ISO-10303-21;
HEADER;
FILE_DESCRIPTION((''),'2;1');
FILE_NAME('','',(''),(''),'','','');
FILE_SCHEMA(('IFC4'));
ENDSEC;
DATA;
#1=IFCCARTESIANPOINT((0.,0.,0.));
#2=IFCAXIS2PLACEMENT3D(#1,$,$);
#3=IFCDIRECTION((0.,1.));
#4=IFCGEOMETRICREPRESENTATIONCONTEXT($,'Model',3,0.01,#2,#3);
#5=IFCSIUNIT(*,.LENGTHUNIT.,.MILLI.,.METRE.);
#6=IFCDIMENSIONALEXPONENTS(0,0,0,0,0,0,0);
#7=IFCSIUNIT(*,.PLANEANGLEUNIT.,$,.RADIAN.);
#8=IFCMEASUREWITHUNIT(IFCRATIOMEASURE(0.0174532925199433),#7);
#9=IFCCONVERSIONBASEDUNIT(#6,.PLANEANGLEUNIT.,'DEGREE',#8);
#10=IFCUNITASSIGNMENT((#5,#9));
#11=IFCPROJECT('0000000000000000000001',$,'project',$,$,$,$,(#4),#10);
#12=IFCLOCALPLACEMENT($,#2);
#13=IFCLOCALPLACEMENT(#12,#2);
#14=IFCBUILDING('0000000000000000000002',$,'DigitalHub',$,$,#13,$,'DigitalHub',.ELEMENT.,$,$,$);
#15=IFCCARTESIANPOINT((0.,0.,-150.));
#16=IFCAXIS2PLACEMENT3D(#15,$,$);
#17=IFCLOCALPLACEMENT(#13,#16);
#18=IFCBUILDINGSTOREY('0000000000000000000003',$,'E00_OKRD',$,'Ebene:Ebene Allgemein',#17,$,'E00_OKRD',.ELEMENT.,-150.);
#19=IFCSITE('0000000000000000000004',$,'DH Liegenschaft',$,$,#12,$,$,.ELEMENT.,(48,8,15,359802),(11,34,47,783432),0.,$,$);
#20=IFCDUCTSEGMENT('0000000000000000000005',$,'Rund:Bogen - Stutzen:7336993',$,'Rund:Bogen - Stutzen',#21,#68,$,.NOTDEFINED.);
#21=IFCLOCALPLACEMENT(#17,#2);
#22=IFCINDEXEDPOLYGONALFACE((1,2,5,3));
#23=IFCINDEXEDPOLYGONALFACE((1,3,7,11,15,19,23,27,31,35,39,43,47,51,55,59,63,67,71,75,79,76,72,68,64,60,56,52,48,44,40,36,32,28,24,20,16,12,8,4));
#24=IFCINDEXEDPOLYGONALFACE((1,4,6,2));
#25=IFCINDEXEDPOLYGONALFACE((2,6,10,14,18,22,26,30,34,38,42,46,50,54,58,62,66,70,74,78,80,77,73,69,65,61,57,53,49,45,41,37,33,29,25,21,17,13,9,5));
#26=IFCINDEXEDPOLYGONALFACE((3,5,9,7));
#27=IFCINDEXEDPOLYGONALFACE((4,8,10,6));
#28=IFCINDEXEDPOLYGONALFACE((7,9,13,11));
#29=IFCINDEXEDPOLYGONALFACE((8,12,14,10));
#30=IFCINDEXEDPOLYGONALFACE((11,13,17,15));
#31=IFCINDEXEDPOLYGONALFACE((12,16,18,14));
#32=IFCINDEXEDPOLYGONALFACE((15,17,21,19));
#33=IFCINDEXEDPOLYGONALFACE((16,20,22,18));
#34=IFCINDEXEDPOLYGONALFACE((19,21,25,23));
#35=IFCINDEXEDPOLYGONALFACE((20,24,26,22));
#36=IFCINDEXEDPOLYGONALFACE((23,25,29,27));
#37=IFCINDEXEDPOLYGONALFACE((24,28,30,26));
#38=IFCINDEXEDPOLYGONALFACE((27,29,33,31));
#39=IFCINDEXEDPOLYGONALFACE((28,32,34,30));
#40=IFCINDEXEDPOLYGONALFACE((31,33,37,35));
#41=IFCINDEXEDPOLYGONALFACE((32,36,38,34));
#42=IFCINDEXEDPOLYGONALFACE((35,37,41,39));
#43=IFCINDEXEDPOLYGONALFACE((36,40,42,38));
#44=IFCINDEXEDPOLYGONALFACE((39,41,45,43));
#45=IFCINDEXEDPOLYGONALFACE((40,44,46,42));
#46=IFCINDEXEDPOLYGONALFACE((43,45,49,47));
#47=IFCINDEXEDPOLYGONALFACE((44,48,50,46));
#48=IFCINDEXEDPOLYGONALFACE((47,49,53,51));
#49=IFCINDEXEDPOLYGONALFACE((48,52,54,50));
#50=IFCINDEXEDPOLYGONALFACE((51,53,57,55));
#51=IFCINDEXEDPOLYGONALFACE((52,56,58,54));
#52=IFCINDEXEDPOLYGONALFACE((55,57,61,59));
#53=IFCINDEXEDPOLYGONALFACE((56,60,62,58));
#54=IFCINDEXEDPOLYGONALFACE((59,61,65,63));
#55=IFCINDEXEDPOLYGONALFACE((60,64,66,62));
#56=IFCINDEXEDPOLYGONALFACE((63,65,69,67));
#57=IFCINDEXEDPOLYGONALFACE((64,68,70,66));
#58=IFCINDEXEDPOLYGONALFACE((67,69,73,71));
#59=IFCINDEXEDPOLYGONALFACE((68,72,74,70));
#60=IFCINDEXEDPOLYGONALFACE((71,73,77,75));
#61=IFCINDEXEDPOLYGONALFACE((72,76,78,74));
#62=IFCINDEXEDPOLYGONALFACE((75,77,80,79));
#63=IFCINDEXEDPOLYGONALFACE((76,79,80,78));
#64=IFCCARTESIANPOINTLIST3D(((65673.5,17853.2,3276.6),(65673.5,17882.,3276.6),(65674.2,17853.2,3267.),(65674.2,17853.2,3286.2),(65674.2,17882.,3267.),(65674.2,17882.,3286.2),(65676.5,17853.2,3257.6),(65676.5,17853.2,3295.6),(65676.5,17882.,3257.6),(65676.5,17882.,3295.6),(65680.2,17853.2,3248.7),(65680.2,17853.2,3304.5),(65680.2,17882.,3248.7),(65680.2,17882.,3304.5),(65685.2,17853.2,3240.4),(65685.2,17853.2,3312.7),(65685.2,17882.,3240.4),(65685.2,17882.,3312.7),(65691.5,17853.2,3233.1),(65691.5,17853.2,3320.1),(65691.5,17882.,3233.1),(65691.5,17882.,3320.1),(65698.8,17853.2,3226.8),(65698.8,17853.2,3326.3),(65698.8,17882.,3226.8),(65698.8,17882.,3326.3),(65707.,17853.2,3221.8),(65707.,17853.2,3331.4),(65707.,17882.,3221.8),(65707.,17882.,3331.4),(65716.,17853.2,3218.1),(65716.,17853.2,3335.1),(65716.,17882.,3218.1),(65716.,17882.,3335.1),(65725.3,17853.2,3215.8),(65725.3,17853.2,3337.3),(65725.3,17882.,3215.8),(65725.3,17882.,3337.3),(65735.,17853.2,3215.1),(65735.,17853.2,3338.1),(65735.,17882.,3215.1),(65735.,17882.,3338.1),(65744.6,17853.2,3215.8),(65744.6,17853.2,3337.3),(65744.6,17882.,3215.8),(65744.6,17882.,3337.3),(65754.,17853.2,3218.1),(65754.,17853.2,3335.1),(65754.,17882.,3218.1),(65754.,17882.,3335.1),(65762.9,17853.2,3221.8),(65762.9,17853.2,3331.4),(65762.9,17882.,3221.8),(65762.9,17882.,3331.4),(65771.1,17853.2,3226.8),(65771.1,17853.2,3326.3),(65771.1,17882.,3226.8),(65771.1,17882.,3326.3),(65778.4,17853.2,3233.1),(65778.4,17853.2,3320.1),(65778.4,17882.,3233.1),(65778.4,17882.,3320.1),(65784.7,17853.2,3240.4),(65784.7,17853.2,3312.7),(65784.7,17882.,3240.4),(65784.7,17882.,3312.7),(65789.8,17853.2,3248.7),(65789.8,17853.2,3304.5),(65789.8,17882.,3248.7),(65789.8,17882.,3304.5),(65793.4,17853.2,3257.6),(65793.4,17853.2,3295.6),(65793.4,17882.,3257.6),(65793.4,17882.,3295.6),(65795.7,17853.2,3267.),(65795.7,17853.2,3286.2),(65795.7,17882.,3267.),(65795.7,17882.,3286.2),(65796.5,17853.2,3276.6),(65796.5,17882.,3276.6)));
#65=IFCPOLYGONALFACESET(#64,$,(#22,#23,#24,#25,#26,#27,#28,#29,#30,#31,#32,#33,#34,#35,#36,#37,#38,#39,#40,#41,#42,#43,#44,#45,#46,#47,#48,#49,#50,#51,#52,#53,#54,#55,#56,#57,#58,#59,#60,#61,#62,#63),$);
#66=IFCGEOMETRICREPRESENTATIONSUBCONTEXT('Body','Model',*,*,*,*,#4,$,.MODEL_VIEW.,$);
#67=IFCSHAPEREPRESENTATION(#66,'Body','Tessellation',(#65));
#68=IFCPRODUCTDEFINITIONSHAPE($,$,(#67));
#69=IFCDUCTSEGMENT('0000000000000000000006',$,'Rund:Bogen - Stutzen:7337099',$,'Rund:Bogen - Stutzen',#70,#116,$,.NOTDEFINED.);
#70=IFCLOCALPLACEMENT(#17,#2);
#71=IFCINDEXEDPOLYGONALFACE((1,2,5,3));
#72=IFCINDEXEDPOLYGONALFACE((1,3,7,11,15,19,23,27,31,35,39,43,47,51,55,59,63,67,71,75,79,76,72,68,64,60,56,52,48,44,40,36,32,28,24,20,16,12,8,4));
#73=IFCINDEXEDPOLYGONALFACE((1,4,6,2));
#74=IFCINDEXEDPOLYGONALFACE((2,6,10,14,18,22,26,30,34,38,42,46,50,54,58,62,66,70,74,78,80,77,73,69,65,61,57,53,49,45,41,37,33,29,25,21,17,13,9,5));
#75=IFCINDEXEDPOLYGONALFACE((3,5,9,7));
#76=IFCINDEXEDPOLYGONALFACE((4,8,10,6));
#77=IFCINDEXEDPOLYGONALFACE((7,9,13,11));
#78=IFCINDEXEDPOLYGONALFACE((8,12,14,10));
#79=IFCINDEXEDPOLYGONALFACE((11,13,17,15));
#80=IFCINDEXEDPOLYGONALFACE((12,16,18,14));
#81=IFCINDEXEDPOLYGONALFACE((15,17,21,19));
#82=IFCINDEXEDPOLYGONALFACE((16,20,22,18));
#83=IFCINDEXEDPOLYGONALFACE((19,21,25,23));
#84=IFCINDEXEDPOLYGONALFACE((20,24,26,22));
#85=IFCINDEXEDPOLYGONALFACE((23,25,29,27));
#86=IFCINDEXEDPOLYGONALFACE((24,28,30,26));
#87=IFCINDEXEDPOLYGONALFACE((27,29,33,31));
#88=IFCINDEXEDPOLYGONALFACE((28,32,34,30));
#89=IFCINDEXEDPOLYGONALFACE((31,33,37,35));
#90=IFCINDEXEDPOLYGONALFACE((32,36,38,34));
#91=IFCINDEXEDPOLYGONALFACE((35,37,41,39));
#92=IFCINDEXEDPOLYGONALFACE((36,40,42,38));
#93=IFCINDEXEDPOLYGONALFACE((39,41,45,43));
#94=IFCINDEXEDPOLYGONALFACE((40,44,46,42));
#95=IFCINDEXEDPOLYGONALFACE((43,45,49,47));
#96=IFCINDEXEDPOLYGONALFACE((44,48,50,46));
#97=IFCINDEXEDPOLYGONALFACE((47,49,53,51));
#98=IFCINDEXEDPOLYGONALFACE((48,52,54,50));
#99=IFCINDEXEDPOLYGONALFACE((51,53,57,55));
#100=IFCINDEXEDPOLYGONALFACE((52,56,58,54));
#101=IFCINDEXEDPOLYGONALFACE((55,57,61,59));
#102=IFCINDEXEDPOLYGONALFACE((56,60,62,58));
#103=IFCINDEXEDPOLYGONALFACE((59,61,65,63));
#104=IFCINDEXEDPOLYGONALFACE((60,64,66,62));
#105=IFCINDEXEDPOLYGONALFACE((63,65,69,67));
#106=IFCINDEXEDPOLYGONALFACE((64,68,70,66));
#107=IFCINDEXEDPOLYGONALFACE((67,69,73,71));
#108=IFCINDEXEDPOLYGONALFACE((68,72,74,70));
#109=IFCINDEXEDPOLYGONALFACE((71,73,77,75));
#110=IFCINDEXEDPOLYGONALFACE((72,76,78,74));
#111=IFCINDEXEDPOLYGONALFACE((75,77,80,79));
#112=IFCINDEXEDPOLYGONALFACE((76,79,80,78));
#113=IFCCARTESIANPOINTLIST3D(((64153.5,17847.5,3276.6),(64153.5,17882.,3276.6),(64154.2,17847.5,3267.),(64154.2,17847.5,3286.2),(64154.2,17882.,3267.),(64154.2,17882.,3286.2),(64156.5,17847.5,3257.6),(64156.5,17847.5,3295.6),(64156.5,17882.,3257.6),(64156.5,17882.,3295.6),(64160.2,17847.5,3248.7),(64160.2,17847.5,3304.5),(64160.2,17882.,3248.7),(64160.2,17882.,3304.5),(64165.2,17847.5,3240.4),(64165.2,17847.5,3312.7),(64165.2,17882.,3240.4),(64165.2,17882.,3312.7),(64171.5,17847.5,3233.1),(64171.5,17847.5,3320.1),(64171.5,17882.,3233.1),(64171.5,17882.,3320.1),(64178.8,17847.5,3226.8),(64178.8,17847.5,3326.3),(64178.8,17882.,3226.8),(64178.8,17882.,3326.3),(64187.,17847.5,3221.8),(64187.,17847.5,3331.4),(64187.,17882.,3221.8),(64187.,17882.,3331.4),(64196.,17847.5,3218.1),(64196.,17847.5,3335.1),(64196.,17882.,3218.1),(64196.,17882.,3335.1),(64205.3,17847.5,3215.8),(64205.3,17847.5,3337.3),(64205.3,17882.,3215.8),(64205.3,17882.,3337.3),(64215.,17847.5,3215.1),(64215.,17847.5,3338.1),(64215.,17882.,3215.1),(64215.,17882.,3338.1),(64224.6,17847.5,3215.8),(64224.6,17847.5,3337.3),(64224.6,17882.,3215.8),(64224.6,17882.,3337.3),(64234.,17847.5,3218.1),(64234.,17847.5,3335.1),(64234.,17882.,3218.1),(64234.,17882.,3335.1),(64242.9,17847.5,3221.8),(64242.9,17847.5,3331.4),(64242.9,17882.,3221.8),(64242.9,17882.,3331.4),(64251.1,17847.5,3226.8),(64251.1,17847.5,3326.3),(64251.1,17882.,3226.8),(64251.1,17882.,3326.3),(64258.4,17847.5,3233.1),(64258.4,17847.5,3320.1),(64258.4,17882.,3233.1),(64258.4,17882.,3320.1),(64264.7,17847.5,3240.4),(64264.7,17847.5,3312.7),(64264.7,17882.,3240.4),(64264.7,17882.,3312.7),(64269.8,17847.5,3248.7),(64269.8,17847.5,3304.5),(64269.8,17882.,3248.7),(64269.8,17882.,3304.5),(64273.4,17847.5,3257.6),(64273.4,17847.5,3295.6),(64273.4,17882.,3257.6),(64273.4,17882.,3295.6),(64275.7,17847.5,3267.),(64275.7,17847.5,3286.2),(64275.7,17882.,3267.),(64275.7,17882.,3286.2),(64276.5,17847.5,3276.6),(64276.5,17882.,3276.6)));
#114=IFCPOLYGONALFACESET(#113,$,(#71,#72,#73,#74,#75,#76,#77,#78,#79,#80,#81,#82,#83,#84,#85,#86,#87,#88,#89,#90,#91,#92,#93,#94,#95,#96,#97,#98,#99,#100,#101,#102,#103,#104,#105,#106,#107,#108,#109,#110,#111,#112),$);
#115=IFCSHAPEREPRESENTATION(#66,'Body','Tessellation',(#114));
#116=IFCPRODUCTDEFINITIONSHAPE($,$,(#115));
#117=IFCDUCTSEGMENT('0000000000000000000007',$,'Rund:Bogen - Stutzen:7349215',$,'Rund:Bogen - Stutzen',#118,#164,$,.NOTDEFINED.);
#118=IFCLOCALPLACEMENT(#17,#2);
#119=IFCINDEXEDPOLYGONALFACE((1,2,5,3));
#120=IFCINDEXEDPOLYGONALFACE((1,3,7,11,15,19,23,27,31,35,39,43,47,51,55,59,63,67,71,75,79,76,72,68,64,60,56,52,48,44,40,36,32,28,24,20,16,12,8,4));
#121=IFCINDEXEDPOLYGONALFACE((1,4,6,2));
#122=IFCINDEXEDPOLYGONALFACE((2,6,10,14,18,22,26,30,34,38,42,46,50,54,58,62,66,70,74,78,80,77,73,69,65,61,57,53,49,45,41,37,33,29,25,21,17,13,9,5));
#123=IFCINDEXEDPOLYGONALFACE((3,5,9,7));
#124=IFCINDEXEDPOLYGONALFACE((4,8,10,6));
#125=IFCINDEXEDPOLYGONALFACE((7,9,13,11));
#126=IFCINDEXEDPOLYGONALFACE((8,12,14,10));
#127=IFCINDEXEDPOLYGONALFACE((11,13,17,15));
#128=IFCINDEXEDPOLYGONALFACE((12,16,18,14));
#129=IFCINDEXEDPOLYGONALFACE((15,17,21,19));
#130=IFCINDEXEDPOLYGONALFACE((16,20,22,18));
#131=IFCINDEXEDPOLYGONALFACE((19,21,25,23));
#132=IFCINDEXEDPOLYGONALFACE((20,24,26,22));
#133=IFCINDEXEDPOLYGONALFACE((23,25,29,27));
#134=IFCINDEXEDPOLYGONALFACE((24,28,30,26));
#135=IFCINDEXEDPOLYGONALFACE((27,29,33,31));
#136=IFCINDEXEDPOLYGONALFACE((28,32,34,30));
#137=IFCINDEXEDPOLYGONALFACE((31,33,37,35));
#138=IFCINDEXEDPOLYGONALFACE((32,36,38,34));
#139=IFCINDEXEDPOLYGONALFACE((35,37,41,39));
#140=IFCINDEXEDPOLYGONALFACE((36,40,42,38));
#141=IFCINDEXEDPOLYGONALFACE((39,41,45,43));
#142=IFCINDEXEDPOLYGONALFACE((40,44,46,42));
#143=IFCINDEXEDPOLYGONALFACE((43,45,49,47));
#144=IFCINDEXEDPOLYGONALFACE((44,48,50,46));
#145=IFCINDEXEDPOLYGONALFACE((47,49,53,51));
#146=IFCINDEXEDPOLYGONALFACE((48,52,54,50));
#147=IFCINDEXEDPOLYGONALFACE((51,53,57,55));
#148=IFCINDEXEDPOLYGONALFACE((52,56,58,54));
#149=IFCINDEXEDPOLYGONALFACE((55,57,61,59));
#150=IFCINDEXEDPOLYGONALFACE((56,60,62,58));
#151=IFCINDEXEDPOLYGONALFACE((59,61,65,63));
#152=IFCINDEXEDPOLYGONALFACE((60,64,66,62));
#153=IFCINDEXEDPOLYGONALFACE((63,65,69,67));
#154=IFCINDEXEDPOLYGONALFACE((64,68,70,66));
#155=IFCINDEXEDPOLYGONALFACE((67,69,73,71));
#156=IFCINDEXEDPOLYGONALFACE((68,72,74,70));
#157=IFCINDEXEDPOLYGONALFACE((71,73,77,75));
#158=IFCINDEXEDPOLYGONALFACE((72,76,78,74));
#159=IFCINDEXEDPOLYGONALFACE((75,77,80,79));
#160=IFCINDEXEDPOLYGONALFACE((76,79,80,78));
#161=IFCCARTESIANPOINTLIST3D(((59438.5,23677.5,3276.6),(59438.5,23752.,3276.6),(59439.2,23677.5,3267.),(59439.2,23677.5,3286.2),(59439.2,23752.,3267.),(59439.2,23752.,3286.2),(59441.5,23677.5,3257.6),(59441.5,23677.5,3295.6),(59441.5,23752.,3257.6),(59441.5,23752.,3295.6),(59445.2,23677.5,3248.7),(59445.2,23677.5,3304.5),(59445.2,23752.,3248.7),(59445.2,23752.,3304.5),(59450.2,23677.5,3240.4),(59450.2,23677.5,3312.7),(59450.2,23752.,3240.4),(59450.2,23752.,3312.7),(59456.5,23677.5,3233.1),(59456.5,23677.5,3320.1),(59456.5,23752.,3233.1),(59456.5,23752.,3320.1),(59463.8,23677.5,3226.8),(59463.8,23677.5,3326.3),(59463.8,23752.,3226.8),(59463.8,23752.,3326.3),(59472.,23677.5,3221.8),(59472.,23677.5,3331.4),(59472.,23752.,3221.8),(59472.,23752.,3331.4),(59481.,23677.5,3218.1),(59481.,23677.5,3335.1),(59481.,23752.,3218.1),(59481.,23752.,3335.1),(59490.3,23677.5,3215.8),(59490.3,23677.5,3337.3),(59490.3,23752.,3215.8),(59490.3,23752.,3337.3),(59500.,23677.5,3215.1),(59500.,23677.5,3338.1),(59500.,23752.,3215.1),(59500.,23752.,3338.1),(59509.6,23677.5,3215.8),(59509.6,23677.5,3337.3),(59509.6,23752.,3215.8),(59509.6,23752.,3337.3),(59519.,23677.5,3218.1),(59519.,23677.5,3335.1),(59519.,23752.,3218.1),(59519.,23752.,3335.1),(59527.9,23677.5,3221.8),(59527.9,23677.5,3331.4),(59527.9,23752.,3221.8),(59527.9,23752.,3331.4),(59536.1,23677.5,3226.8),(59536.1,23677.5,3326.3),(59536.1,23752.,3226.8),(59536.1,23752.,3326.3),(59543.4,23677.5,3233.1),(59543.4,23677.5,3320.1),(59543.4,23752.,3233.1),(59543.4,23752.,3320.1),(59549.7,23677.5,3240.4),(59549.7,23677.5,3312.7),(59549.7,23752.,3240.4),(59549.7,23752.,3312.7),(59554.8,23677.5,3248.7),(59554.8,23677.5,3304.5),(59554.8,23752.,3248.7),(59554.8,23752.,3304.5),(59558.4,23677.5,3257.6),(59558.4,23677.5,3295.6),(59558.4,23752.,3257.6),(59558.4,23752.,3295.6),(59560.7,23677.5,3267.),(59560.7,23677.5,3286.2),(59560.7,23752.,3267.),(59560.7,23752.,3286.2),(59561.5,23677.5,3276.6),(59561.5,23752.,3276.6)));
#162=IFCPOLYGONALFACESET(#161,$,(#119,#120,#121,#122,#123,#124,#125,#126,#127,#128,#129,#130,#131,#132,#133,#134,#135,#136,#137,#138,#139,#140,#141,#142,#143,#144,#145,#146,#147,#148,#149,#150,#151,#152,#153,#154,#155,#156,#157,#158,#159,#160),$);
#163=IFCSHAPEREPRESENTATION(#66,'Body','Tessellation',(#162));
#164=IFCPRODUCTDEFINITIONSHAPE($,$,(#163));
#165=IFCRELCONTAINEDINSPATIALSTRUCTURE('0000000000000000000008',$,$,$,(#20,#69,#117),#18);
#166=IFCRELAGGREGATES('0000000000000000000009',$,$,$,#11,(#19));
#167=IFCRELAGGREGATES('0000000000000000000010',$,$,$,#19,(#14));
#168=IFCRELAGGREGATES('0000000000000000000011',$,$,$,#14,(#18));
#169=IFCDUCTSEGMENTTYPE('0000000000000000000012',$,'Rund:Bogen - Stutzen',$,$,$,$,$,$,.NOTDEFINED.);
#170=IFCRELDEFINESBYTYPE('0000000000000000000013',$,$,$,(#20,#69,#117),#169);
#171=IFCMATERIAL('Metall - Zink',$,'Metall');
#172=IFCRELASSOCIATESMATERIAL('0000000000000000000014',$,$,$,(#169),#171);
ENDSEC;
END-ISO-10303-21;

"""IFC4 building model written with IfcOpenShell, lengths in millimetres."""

from ifc_helpers import new_model, entity, si_unit, converted_unit, direction, frame, origin, place, context, subcontext, project, spatial, indexed_curve, outline, extrude, material, type_object, element, save


model = new_model("IFC4")

# Units and contexts
model_context = context("Model", 3, precision=0.01, world=origin(), true_north=direction((0.0, 1.0)))
body_context = subcontext(model_context, "Body", "Model", "MODEL_VIEW")
ifc_project = project(units=[si_unit("LENGTHUNIT", "METRE", prefix="MILLI"), converted_unit("PLANEANGLEUNIT", "DEGREE", entity("IfcRatioMeasure", 0.0174532925199433), si_unit("PLANEANGLEUNIT", "RADIAN"), dimensions=[0, 0, 0, 0, 0, 0, 0])], contexts=[model_context])

# Site, building, storey
site_placement = place(None, origin())
site = spatial("IfcSite", under=ifc_project, at=site_placement, Name="DH Liegenschaft", CompositionType="ELEMENT", RefLatitude=(48, 8, 15, 359802), RefLongitude=(11, 34, 47, 783432), RefElevation=0.0)
building_placement = place(site_placement, origin())
building = spatial("IfcBuilding", under=site, at=building_placement, Name="DigitalHub", LongName="DigitalHub", CompositionType="ELEMENT")
storey_placement = place(building_placement, frame((0.0, 0.0, -150.0)))
storey = spatial("IfcBuildingStorey", under=building, at=storey_placement, Name="E00_OKRD", ObjectType="Ebene:Ebene Allgemein", LongName="E00_OKRD", CompositionType="ELEMENT", Elevation=-150.0)

# Shared definitions
ifc_material_1 = material(Name="Metall - Zink", Category="Metall")

# Duct segments
duct_segment_type_1 = type_object("IfcDuctSegmentType", Name="Rund:Bogen - Stutzen", PredefinedType="NOTDEFINED", material=ifc_material_1)
duct_segment_1_placement = place(storey_placement, frame((65671.9, 17853.2, 3213.5)))
element("IfcDuctSegment", 1, at=duct_segment_1_placement, inside=storey, type_object=duct_segment_type_1, Name="Rund:Bogen - Stutzen:7336993", ObjectType="Rund:Bogen - Stutzen", PredefinedType="NOTDEFINED", context=body_context, shape_type="SweptSolid", body=[
    extrude(outline(indexed_curve([(61.5, 0.0), (60.7, 9.6), (58.5, 19.0), (54.8, 27.9), (49.8, 36.1), (43.5, 43.5), (36.1, 49.8), (27.9, 54.8), (19.0, 58.5), (9.6, 60.7), (0.0, 61.5), (-9.6, 60.7), (-19.0, 58.5), (-27.9, 54.8), (-36.1, 49.8), (-43.5, 43.5), (-49.8, 36.1), (-54.8, 27.9), (-58.5, 19.0), (-60.7, 9.6), (-61.5, 0.0), (-60.7, -9.6), (-58.5, -19.0), (-54.8, -27.9), (-49.8, -36.1), (-43.5, -43.5), (-36.1, -49.8), (-27.9, -54.8), (-19.0, -58.5), (-9.6, -60.7), (0.0, -61.5), (9.6, -60.7), (19.0, -58.5), (27.9, -54.8), (36.1, -49.8), (43.5, -43.5), (49.8, -36.1), (54.8, -27.9), (58.5, -19.0), (60.7, -9.6), (61.5, 0.0)], self_intersect=False)), frame((63.1, 0.0, 63.1), z_axis=(0.0, 1.0, 0.0), x_axis=(1.0, 0.0, 0.0)), (0.0, 0.0, 1.0), 28.8),
])
duct_segment_2_placement = place(storey_placement, frame((64151.9, 17847.5, 3213.5)))
element("IfcDuctSegment", 2, at=duct_segment_2_placement, inside=storey, type_object=duct_segment_type_1, Name="Rund:Bogen - Stutzen:7337099", ObjectType="Rund:Bogen - Stutzen", PredefinedType="NOTDEFINED", context=body_context, shape_type="SweptSolid", body=[
    extrude(outline(indexed_curve([(61.5, 0.0), (60.7, 9.6), (58.5, 19.0), (54.8, 27.9), (49.8, 36.1), (43.5, 43.5), (36.1, 49.8), (27.9, 54.8), (19.0, 58.5), (9.6, 60.7), (0.0, 61.5), (-9.6, 60.7), (-19.0, 58.5), (-27.9, 54.8), (-36.1, 49.8), (-43.5, 43.5), (-49.8, 36.1), (-54.8, 27.9), (-58.5, 19.0), (-60.7, 9.6), (-61.5, 0.0), (-60.7, -9.6), (-58.5, -19.0), (-54.8, -27.9), (-49.8, -36.1), (-43.5, -43.5), (-36.1, -49.8), (-27.9, -54.8), (-19.0, -58.5), (-9.6, -60.7), (0.0, -61.5), (9.6, -60.7), (19.0, -58.5), (27.9, -54.8), (36.1, -49.8), (43.5, -43.5), (49.8, -36.1), (54.8, -27.9), (58.5, -19.0), (60.7, -9.6), (61.5, 0.0)], self_intersect=False)), frame((63.1, 0.0, 63.1), z_axis=(0.0, 1.0, 0.0), x_axis=(1.0, 0.0, 0.0)), (0.0, 0.0, 1.0), 34.5),
])
duct_segment_3_placement = place(storey_placement, frame((59436.9, 23677.5, 3213.5)))
element("IfcDuctSegment", 3, at=duct_segment_3_placement, inside=storey, type_object=duct_segment_type_1, Name="Rund:Bogen - Stutzen:7349215", ObjectType="Rund:Bogen - Stutzen", PredefinedType="NOTDEFINED", context=body_context, shape_type="SweptSolid", body=[
    extrude(outline(indexed_curve([(61.5, 0.0), (60.7, 9.6), (58.5, 19.0), (54.8, 27.9), (49.8, 36.1), (43.5, 43.5), (36.1, 49.8), (27.9, 54.8), (19.0, 58.5), (9.6, 60.7), (0.0, 61.5), (-9.6, 60.7), (-19.0, 58.5), (-27.9, 54.8), (-36.1, 49.8), (-43.5, 43.5), (-49.8, 36.1), (-54.8, 27.9), (-58.5, 19.0), (-60.7, 9.6), (-61.5, 0.0), (-60.7, -9.6), (-58.5, -19.0), (-54.8, -27.9), (-49.8, -36.1), (-43.5, -43.5), (-36.1, -49.8), (-27.9, -54.8), (-19.0, -58.5), (-9.6, -60.7), (0.0, -61.5), (9.6, -60.7), (19.0, -58.5), (27.9, -54.8), (36.1, -49.8), (43.5, -43.5), (49.8, -36.1), (54.8, -27.9), (58.5, -19.0), (60.7, -9.6), (61.5, 0.0)], self_intersect=False)), frame((63.1, 0.0, 63.1), z_axis=(0.0, 1.0, 0.0), x_axis=(1.0, 0.0, 0.0)), (0.0, 0.0, 1.0), 74.5),
])

save(model, "model.ifc")
